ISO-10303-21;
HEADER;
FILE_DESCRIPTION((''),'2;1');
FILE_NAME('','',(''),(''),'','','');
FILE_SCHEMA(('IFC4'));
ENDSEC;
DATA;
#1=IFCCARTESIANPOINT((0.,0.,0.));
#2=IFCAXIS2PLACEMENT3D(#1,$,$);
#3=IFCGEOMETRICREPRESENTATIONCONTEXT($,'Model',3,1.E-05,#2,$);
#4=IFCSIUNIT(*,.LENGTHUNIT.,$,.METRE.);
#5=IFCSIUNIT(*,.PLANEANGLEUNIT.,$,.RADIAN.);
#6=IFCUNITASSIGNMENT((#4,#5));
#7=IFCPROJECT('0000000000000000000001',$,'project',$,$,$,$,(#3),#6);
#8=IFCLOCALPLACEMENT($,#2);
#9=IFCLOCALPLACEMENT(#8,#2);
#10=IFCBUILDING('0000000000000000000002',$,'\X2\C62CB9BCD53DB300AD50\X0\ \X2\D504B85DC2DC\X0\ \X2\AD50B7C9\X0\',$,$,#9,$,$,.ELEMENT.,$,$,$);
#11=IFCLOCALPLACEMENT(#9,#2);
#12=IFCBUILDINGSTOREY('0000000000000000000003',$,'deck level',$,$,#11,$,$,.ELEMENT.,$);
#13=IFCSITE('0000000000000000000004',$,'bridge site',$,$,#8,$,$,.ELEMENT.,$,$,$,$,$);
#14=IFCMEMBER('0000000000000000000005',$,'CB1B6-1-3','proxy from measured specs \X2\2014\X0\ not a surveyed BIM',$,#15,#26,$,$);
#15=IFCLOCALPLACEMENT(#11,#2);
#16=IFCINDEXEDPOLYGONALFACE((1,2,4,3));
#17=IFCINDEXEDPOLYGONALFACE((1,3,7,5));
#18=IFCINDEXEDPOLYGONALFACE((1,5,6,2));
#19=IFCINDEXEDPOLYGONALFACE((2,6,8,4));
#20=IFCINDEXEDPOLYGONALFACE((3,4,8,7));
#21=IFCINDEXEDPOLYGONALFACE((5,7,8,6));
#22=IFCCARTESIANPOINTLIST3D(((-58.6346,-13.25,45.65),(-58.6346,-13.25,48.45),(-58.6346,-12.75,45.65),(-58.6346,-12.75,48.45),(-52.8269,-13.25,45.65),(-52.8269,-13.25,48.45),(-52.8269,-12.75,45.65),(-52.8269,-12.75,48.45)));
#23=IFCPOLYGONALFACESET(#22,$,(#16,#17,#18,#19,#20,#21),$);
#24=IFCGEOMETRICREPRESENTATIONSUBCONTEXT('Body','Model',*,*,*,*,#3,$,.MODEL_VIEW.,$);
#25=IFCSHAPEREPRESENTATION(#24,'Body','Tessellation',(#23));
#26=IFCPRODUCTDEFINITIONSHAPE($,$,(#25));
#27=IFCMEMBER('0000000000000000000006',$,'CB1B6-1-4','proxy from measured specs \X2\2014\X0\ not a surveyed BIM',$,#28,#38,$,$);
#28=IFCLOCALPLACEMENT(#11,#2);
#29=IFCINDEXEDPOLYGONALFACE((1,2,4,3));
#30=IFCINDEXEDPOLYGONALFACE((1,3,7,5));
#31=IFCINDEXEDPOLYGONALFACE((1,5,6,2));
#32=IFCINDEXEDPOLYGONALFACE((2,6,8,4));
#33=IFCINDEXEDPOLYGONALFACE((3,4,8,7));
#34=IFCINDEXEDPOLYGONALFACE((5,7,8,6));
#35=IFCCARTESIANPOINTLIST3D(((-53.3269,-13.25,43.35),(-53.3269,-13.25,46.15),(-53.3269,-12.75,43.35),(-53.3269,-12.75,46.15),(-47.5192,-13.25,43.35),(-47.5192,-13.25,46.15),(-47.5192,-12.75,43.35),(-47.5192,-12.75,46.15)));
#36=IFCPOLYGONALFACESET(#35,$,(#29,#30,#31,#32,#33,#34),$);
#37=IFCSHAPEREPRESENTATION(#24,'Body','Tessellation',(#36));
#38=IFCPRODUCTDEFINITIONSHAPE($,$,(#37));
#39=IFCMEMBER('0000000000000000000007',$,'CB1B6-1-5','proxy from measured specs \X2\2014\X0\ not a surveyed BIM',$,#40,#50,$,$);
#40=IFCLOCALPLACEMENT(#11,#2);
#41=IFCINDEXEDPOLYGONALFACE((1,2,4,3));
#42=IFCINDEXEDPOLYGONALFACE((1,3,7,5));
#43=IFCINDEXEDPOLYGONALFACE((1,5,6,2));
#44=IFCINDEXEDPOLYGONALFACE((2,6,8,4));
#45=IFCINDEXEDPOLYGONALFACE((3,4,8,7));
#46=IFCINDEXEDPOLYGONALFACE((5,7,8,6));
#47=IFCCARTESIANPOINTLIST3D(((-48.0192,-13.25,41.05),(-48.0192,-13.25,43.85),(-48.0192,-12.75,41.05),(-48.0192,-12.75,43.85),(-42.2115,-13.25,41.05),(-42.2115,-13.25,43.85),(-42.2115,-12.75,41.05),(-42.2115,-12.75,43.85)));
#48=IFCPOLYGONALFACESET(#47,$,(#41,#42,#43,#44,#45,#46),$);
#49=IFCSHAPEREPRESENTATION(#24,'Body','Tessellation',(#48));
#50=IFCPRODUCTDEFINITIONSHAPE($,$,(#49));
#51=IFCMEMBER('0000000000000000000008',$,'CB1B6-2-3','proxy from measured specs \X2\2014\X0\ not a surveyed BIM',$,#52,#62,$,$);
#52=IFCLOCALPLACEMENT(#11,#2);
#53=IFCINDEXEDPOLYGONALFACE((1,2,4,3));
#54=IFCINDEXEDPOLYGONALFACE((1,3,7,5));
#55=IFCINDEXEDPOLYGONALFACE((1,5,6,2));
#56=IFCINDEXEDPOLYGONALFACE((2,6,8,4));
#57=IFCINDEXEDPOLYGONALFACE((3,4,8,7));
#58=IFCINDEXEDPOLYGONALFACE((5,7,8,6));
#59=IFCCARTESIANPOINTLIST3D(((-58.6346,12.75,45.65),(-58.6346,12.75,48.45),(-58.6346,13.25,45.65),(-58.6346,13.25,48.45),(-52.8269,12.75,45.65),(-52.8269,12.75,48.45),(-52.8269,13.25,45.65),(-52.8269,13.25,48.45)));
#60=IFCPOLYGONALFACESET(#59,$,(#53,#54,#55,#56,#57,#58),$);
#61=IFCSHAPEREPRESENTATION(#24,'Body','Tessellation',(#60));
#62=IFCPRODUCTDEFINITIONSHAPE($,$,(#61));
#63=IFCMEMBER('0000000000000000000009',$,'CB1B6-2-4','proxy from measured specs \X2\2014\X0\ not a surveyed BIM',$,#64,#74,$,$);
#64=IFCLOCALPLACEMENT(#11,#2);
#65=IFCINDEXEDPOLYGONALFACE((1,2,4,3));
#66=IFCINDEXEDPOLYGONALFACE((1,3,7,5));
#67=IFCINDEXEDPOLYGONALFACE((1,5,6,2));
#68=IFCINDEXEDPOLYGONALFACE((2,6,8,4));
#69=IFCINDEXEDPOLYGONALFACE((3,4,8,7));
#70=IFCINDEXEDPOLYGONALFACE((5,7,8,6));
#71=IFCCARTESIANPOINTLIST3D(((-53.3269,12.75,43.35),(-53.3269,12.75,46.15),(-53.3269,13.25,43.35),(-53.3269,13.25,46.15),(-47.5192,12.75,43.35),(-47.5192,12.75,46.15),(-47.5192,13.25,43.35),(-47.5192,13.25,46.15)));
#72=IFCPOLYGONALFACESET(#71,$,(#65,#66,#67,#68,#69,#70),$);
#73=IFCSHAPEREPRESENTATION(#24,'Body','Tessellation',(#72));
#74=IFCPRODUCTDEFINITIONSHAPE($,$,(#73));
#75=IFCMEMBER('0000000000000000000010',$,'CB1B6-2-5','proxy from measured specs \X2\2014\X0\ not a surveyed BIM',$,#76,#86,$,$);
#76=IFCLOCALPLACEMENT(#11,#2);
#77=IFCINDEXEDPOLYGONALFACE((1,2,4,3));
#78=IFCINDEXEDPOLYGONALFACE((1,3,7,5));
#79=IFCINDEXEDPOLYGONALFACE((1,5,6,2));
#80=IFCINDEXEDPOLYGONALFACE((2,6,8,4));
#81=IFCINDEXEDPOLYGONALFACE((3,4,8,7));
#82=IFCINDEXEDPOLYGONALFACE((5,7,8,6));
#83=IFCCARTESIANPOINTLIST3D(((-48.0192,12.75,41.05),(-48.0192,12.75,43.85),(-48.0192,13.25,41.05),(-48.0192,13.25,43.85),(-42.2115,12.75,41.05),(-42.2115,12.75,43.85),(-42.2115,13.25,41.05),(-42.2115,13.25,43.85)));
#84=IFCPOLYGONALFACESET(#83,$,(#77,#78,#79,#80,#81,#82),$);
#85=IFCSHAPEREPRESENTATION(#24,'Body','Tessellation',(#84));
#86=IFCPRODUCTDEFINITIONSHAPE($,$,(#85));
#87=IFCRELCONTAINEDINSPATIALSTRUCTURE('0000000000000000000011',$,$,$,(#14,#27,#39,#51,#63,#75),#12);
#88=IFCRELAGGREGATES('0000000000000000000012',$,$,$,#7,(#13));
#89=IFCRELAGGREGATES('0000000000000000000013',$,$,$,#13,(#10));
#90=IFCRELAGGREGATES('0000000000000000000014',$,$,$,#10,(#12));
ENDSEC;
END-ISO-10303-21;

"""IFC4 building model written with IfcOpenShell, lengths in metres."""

from ifc_helpers import new_model, si_unit, frame, origin, origin_2d, place, context, subcontext, project, spatial, rectangle, extrude, element, save


model = new_model("IFC4")

# Units and contexts
model_context = context("Model", 3, precision=1e-05, world=origin())
body_context = subcontext(model_context, "Body", "Model", "MODEL_VIEW")
ifc_project = project(units=[si_unit("LENGTHUNIT", "METRE"), si_unit("PLANEANGLEUNIT", "RADIAN")], contexts=[model_context])

# Site, building, storey
site_placement = place(None, origin())
site = spatial("IfcSite", under=ifc_project, at=site_placement, Name="bridge site", CompositionType="ELEMENT")
building_placement = place(site_placement, origin())
building = spatial("IfcBuilding", under=site, at=building_placement, Name="올림픽대교 프록시 교량", CompositionType="ELEMENT")
storey_placement = place(building_placement, origin())
storey = spatial("IfcBuildingStorey", under=building, at=storey_placement, Name="deck level", CompositionType="ELEMENT")

# Members
member_1_placement = place(storey_placement, frame((-55.7308, -13.0, 45.65)))
element("IfcMember", 1, at=member_1_placement, inside=storey, Name="CB1B6-1-3", Description="proxy from measured specs — not a surveyed BIM", context=body_context, shape_type="SweptSolid", body=[
    extrude(rectangle(XDim=5.8077, YDim=0.5, at=origin_2d()), origin(), (0.0, 0.0, 1.0), 2.8),
])
member_2_placement = place(storey_placement, frame((-50.4231, -13.0, 43.35)))
element("IfcMember", 2, at=member_2_placement, inside=storey, Name="CB1B6-1-4", Description="proxy from measured specs — not a surveyed BIM", context=body_context, shape_type="SweptSolid", body=[
    extrude(rectangle(XDim=5.8077, YDim=0.5, at=origin_2d()), origin(), (0.0, 0.0, 1.0), 2.8),
])
member_3_placement = place(storey_placement, frame((-45.1154, -13.0, 41.05)))
element("IfcMember", 3, at=member_3_placement, inside=storey, Name="CB1B6-1-5", Description="proxy from measured specs — not a surveyed BIM", context=body_context, shape_type="SweptSolid", body=[
    extrude(rectangle(XDim=5.8077, YDim=0.5, at=origin_2d()), origin(), (0.0, 0.0, 1.0), 2.8),
])
member_4_placement = place(storey_placement, frame((-55.7308, 13.0, 45.65)))
element("IfcMember", 4, at=member_4_placement, inside=storey, Name="CB1B6-2-3", Description="proxy from measured specs — not a surveyed BIM", context=body_context, shape_type="SweptSolid", body=[
    extrude(rectangle(XDim=5.8077, YDim=0.5, at=origin_2d()), origin(), (0.0, 0.0, 1.0), 2.8),
])
member_5_placement = place(storey_placement, frame((-50.4231, 13.0, 43.35)))
element("IfcMember", 5, at=member_5_placement, inside=storey, Name="CB1B6-2-4", Description="proxy from measured specs — not a surveyed BIM", context=body_context, shape_type="SweptSolid", body=[
    extrude(rectangle(XDim=5.8077, YDim=0.5, at=origin_2d()), origin(), (0.0, 0.0, 1.0), 2.8),
])
member_6_placement = place(storey_placement, frame((-45.1154, 13.0, 41.05)))
element("IfcMember", 6, at=member_6_placement, inside=storey, Name="CB1B6-2-5", Description="proxy from measured specs — not a surveyed BIM", context=body_context, shape_type="SweptSolid", body=[
    extrude(rectangle(XDim=5.8077, YDim=0.5, at=origin_2d()), origin(), (0.0, 0.0, 1.0), 2.8),
])

save(model, "model.ifc")
